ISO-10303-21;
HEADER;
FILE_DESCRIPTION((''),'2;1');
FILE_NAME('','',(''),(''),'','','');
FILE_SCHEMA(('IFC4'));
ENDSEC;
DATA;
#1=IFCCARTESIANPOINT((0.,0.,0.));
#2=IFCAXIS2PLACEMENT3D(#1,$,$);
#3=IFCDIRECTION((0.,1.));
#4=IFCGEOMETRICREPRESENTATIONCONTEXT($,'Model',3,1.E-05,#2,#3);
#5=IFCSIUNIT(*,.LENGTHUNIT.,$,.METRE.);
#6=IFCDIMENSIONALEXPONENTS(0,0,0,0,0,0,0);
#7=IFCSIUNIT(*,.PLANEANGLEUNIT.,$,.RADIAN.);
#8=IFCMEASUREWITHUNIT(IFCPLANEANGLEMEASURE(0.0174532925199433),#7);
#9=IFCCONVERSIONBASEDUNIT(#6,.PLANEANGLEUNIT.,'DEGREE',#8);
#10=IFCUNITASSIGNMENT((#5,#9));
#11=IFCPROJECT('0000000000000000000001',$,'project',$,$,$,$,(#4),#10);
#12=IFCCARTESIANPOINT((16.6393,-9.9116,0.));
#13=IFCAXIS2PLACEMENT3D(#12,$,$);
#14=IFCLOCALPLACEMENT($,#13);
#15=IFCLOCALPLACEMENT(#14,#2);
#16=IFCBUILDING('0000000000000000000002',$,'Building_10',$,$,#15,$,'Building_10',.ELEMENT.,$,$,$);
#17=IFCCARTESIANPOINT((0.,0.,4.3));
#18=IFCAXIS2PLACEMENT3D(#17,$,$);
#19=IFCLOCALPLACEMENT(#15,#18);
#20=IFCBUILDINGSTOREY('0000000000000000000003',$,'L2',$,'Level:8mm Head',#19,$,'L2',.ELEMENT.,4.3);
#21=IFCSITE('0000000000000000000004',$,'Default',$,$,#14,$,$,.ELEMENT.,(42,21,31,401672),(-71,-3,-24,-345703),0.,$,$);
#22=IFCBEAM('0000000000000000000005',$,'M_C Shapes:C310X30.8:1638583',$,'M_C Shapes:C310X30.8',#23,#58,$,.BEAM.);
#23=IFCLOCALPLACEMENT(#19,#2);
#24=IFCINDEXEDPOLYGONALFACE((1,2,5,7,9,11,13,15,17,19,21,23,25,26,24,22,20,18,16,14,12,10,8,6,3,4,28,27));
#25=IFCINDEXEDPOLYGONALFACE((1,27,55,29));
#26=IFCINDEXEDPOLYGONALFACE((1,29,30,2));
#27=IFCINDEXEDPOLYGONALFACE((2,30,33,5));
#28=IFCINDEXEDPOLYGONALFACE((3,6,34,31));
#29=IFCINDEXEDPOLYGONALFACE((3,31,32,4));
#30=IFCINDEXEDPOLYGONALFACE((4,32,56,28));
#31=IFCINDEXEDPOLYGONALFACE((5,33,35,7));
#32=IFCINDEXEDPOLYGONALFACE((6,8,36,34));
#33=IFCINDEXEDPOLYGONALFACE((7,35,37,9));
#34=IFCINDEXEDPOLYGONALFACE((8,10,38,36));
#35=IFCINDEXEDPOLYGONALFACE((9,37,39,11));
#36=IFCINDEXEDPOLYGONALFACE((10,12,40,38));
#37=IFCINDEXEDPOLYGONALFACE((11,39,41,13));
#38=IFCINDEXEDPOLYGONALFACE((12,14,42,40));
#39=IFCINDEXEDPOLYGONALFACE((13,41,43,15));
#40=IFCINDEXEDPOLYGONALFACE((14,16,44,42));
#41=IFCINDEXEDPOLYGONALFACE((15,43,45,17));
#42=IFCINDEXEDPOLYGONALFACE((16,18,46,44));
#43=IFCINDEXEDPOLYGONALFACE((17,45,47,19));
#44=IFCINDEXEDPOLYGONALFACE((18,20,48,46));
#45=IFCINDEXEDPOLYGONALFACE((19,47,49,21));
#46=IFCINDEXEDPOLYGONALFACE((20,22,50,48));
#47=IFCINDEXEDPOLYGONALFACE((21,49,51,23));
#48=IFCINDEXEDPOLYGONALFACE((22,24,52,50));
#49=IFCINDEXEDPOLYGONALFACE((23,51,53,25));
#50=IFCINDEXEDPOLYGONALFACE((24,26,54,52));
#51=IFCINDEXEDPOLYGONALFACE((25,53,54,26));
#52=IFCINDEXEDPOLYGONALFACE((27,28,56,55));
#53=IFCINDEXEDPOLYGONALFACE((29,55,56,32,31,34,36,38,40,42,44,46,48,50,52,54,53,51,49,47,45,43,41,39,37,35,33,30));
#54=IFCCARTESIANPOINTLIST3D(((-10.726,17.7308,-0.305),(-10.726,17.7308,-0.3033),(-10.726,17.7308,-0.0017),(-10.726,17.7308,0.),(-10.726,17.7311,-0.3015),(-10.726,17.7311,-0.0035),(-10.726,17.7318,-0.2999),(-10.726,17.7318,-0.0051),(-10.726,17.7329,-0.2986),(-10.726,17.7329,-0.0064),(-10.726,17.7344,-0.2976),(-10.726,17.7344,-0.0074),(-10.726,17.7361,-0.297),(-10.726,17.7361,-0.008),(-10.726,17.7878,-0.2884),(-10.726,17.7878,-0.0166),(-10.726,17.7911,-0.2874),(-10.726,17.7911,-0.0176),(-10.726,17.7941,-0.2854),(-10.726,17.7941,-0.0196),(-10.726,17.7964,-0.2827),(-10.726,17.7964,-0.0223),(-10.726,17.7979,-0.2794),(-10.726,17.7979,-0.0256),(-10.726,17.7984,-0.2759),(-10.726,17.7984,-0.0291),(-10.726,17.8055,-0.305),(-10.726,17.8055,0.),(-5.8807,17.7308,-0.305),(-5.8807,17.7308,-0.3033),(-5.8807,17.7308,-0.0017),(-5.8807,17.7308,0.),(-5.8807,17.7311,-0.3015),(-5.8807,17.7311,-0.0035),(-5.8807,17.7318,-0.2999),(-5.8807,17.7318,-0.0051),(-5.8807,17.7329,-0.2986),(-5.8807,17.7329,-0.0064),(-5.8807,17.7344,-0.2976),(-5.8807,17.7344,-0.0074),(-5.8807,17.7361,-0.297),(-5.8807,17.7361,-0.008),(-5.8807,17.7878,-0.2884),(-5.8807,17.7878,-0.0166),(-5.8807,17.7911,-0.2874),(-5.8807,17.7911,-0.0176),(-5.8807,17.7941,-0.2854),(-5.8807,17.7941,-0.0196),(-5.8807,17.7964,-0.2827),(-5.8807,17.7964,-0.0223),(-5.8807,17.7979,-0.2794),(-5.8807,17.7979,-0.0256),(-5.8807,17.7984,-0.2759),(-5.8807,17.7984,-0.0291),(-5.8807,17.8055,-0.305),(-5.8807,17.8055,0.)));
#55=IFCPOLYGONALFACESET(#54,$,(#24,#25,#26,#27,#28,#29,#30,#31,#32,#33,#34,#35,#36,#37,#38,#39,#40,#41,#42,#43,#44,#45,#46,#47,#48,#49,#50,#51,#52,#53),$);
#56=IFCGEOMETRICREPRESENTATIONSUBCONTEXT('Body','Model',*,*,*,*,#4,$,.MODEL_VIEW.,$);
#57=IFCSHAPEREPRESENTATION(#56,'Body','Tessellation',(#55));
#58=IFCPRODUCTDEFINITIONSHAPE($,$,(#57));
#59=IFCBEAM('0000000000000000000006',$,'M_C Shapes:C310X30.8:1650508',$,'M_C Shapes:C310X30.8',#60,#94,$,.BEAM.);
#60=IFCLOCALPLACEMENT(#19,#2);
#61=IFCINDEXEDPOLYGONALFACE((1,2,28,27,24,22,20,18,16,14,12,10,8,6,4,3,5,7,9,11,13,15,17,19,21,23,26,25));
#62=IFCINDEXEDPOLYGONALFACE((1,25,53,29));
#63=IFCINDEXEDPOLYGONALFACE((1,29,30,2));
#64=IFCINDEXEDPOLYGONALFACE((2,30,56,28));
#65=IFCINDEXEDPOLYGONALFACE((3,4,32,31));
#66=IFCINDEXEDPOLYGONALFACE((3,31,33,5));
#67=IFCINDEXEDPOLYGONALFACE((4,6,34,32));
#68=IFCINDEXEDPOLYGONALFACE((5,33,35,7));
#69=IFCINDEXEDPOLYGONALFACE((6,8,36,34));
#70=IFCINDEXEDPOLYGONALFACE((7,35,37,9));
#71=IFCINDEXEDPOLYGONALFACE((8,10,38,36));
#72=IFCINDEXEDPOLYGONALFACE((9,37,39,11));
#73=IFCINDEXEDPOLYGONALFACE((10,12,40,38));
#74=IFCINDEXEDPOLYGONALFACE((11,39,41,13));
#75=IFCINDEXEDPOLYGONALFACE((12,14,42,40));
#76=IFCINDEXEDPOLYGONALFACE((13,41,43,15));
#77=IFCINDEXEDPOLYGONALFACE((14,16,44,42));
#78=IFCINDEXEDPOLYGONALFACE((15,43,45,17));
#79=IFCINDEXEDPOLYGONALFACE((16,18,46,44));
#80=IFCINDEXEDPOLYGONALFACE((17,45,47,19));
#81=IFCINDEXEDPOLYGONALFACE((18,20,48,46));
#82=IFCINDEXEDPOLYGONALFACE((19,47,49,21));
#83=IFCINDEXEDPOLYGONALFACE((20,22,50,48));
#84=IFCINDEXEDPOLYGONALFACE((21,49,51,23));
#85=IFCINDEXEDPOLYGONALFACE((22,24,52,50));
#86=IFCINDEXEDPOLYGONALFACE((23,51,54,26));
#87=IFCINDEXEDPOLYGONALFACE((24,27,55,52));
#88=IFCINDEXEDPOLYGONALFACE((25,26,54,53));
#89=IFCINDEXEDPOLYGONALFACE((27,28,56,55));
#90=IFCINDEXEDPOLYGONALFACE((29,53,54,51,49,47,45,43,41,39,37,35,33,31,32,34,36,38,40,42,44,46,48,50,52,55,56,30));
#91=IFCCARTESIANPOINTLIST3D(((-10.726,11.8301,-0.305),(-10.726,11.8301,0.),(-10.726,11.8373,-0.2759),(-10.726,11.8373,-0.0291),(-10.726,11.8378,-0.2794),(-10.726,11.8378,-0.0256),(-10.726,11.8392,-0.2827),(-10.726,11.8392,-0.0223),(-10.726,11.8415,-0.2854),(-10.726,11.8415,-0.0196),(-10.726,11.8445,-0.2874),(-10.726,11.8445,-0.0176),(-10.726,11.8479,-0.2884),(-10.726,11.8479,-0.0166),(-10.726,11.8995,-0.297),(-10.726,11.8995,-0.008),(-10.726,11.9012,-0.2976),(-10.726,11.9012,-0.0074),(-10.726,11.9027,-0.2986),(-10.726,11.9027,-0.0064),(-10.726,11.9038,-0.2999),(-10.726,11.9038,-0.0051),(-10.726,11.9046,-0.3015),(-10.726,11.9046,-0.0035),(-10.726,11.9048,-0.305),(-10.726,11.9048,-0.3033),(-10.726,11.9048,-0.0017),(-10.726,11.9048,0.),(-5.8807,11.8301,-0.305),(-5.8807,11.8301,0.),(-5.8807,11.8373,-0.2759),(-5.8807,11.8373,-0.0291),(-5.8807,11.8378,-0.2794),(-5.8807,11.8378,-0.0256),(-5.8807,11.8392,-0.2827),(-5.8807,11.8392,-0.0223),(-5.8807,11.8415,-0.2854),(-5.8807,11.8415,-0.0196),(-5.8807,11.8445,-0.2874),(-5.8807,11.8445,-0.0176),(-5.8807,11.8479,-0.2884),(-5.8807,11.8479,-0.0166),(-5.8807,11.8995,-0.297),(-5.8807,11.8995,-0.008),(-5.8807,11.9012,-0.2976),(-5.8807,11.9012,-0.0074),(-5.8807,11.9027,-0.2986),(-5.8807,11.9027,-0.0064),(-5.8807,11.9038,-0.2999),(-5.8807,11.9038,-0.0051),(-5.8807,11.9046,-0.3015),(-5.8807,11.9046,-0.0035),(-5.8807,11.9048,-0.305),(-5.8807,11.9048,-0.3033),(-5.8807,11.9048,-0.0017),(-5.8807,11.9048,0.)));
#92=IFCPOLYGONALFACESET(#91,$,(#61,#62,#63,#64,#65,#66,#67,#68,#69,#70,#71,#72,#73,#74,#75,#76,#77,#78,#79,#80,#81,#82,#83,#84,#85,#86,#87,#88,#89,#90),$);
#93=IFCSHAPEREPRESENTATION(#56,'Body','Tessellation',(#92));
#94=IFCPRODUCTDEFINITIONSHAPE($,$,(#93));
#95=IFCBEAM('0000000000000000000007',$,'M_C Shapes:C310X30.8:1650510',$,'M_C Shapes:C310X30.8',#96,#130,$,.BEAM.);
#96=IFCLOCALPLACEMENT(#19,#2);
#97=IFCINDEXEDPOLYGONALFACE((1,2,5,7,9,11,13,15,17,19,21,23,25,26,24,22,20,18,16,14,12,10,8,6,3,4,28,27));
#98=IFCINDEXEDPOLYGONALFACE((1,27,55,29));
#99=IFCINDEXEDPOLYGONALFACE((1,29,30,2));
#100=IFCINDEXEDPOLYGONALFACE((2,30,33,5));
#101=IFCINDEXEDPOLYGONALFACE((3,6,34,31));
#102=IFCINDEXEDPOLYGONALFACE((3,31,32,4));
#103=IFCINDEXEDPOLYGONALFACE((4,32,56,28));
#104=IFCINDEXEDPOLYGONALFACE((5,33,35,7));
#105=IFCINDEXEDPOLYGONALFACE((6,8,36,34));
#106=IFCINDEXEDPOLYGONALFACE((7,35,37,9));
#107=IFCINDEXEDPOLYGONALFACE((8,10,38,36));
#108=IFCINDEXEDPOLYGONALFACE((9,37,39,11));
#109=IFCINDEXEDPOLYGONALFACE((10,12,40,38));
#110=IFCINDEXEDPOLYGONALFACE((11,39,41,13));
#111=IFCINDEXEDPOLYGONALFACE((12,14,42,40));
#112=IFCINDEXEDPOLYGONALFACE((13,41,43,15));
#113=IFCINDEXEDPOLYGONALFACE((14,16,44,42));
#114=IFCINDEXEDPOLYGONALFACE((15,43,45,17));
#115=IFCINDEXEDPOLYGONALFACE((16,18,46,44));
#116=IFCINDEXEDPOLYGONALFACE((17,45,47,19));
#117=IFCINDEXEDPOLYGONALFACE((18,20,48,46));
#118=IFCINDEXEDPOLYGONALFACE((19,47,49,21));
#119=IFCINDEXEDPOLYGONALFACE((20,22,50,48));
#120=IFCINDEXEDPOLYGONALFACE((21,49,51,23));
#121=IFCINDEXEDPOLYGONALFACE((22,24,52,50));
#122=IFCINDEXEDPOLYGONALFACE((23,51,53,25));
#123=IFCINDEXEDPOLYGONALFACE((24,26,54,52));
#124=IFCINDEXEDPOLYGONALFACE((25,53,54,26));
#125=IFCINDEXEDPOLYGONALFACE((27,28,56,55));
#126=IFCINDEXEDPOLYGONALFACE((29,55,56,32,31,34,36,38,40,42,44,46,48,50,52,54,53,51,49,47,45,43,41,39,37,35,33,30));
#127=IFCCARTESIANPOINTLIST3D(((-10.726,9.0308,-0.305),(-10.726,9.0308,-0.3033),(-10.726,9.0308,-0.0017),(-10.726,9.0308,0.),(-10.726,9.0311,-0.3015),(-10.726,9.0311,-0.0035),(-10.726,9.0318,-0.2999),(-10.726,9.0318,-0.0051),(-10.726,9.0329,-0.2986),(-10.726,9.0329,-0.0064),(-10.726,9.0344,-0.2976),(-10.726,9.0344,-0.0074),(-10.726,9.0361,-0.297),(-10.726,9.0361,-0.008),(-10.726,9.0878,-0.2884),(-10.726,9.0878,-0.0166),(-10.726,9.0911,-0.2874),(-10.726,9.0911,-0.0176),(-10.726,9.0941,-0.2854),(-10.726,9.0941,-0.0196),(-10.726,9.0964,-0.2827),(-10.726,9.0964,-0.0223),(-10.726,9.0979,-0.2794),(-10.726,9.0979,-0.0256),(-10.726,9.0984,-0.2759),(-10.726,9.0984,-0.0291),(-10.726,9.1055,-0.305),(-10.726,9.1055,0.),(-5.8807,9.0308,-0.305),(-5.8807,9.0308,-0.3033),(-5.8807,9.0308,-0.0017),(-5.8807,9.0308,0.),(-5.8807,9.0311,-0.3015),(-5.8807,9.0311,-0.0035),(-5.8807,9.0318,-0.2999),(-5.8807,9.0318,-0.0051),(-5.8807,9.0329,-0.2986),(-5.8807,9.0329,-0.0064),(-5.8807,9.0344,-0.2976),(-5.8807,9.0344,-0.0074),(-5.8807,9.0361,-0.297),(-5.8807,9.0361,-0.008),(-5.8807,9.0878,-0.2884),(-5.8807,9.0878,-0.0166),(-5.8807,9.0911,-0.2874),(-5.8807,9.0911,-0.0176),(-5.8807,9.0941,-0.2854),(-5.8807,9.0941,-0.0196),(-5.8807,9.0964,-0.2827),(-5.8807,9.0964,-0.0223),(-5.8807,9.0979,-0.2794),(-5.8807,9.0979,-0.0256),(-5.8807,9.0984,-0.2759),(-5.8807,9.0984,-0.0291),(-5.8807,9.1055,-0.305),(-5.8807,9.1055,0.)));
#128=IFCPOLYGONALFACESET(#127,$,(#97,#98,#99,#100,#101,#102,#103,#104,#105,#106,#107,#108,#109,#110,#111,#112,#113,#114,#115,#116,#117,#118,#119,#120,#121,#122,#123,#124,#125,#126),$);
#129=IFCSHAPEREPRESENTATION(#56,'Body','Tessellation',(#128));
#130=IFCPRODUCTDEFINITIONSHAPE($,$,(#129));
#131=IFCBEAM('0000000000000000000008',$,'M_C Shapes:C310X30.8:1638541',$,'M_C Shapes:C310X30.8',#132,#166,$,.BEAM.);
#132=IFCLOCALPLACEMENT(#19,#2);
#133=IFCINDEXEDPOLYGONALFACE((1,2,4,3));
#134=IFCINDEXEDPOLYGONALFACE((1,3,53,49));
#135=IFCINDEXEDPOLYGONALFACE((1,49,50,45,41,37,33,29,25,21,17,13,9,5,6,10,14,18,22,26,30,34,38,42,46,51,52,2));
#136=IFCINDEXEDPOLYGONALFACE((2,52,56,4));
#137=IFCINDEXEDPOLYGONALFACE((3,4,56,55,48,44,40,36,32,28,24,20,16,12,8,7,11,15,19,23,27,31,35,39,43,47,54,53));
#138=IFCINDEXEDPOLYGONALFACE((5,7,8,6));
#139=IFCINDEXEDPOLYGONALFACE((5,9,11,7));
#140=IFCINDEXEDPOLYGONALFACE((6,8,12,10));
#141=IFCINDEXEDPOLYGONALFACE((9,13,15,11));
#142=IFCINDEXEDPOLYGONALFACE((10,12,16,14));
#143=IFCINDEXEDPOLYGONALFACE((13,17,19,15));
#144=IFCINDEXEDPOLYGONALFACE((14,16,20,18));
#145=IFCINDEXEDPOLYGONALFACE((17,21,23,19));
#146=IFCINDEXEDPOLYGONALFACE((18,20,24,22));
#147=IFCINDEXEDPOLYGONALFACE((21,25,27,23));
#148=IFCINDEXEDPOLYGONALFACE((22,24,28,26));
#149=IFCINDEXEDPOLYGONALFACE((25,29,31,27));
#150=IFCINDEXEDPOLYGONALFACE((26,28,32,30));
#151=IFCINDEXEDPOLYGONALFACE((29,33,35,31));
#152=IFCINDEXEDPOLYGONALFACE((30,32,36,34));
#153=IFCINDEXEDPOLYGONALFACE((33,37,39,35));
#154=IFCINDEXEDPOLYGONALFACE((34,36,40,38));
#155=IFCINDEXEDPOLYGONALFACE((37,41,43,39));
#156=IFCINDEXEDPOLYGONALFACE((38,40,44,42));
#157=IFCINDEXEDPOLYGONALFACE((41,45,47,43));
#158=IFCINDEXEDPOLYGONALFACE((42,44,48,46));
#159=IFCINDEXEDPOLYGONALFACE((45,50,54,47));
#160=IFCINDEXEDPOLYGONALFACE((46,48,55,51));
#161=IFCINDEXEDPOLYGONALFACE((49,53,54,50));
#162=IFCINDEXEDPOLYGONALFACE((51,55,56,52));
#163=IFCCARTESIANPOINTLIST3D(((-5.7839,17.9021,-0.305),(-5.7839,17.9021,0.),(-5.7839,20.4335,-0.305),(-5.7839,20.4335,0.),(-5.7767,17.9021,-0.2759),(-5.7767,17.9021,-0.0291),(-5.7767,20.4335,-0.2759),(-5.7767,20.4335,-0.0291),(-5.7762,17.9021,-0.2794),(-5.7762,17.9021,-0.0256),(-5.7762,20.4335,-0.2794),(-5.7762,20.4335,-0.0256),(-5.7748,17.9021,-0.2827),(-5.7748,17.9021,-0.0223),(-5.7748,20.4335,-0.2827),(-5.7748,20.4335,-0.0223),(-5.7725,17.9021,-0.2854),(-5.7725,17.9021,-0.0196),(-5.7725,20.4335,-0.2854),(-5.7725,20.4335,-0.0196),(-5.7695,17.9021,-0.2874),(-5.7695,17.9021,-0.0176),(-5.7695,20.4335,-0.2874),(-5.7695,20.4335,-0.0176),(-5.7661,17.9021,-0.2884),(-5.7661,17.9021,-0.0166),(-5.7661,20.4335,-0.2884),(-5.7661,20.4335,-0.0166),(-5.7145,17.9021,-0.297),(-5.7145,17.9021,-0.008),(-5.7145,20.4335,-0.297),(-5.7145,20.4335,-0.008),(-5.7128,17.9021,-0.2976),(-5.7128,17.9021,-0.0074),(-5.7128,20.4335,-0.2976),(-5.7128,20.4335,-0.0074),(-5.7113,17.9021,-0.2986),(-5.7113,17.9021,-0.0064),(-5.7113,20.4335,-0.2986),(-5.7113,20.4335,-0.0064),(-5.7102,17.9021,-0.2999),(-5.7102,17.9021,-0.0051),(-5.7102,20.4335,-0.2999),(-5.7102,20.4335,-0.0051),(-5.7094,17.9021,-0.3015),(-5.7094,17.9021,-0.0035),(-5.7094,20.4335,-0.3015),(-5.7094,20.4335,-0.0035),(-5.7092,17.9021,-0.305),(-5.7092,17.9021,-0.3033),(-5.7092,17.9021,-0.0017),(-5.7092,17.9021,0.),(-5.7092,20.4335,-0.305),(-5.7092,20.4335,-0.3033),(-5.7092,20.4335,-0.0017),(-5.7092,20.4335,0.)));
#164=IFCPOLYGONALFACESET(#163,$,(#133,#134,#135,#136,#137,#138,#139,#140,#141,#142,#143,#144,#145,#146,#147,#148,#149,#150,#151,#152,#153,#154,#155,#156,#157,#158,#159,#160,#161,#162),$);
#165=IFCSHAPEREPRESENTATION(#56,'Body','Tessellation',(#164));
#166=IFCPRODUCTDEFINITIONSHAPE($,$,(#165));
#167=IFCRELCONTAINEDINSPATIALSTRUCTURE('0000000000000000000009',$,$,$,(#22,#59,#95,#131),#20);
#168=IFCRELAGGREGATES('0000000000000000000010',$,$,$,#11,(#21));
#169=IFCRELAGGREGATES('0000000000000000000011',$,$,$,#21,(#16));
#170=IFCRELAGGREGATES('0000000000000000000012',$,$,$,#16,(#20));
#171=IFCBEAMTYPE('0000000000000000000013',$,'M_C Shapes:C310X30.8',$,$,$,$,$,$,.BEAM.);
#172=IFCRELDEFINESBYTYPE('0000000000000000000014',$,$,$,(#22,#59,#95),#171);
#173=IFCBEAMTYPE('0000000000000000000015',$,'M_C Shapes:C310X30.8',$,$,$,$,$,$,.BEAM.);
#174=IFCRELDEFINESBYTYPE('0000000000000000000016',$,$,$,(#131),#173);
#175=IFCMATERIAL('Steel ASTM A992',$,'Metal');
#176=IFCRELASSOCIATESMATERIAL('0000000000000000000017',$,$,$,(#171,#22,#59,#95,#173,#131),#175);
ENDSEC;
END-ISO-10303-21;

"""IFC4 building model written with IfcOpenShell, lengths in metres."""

from ifc_helpers import new_model, entity, si_unit, converted_unit, direction, frame, origin, place, context, subcontext, project, spatial, line, arc, indexed_curve, outline, extrude, source, transform, mapped, material, type_object, type_shapes, element, save


model = new_model("IFC4")

# Units and contexts
model_context = context("Model", 3, precision=1e-05, world=origin(), true_north=direction((0.0, 1.0)))
body_context = subcontext(model_context, "Body", "Model", "MODEL_VIEW")
ifc_project = project(units=[si_unit("LENGTHUNIT", "METRE"), converted_unit("PLANEANGLEUNIT", "DEGREE", entity("IfcPlaneAngleMeasure", 0.0174532925199433), si_unit("PLANEANGLEUNIT", "RADIAN"), dimensions=[0, 0, 0, 0, 0, 0, 0])], contexts=[model_context])

# Site, building, storey
site_placement = place(None, frame((16.6393, -9.9116, 0.0)))
site = spatial("IfcSite", under=ifc_project, at=site_placement, Name="Default", CompositionType="ELEMENT", RefLatitude=(42, 21, 31, 401672), RefLongitude=(-71, -3, -24, -345703), RefElevation=0.0)
building_placement = place(site_placement, origin())
building = spatial("IfcBuilding", under=site, at=building_placement, Name="Building_10", LongName="Building_10", CompositionType="ELEMENT")
storey_placement = place(building_placement, frame((0.0, 0.0, 4.3)))
storey = spatial("IfcBuildingStorey", under=building, at=storey_placement, Name="L2", ObjectType="Level:8mm Head", LongName="L2", CompositionType="ELEMENT", Elevation=4.3)

# Shared definitions
ifc_material_1 = material(Name="Steel ASTM A992", Category="Metal")

# Beams
beam_type_1 = type_object("IfcBeamType", Name="M_C Shapes:C310X30.8", PredefinedType="BEAM", material=ifc_material_1)
shared_shape_1 = source(origin(), body_context, "Body", "SweptSolid", [
    extrude(outline(indexed_curve([(-0.0406, -0.1525), (0.0341, -0.1525), (0.0341, -0.1508), (0.0326, -0.1467), (0.0288, -0.1445), (-0.0228, -0.1359), (-0.0305, -0.1316), (-0.0335, -0.1234), (-0.0335, 0.1234), (-0.0305, 0.1316), (-0.0228, 0.1359), (0.0288, 0.1445), (0.0326, 0.1467), (0.0341, 0.1508), (0.0341, 0.1525), (-0.0406, 0.1525)], segments=[line(1, 2, 3), arc(3, 4, 5), line(5, 6), arc(6, 7, 8), line(8, 9), arc(9, 10, 11), line(11, 12), arc(12, 13, 14), line(14, 15, 16, 1)], self_intersect=False)), frame((-2.4226, -0.0229, 0.0), z_axis=(1.0, 0.0, 0.0), x_axis=(0.0, -1.0, 0.0)), (0.0, 0.0, 1.0), 4.8453),
])
type_shapes(beam_type_1, [shared_shape_1])
beam_1_placement = place(storey_placement, frame((-8.3033, 17.7878, -0.1525)))
element("IfcBeam", 1, at=beam_1_placement, inside=storey, type_object=beam_type_1, material=ifc_material_1, Name="M_C Shapes:C310X30.8:1638583", ObjectType="M_C Shapes:C310X30.8", PredefinedType="BEAM", context=body_context, shape_type="MappedRepresentation", body=[
    mapped(shared_shape_1, transform((0.0, 0.0, 0.0), scale=1.0)),
])
beam_2_placement = place(storey_placement, frame((-8.3033, 11.8478, -0.1525), z_axis=(0.0, 0.0, 1.0), x_axis=(-1.0, 0.0, 0.0)))
element("IfcBeam", 2, at=beam_2_placement, inside=storey, type_object=beam_type_1, material=ifc_material_1, Name="M_C Shapes:C310X30.8:1650508", ObjectType="M_C Shapes:C310X30.8", PredefinedType="BEAM", context=body_context, shape_type="MappedRepresentation", body=[
    mapped(shared_shape_1, transform((0.0, 0.0, 0.0), scale=1.0)),
])
beam_3_placement = place(storey_placement, frame((-8.3033, 9.0878, -0.1525)))
element("IfcBeam", 3, at=beam_3_placement, inside=storey, type_object=beam_type_1, material=ifc_material_1, Name="M_C Shapes:C310X30.8:1650510", ObjectType="M_C Shapes:C310X30.8", PredefinedType="BEAM", context=body_context, shape_type="MappedRepresentation", body=[
    mapped(shared_shape_1, transform((0.0, 0.0, 0.0), scale=1.0)),
])
beam_type_2 = type_object("IfcBeamType", Name="M_C Shapes:C310X30.8", PredefinedType="BEAM", material=ifc_material_1)
shared_shape_2 = source(origin(), body_context, "Body", "SweptSolid", [
    extrude(outline(indexed_curve([(-0.0406, -0.1525), (0.0341, -0.1525), (0.0341, -0.1508), (0.0326, -0.1467), (0.0288, -0.1445), (-0.0228, -0.1359), (-0.0305, -0.1316), (-0.0335, -0.1234), (-0.0335, 0.1234), (-0.0305, 0.1316), (-0.0228, 0.1359), (0.0288, 0.1445), (0.0326, 0.1467), (0.0341, 0.1508), (0.0341, 0.1525), (-0.0406, 0.1525)], segments=[line(1, 2, 3), arc(3, 4, 5), line(5, 6), arc(6, 7, 8), line(8, 9), arc(9, 10, 11), line(11, 12), arc(12, 13, 14), line(14, 15, 16, 1)], self_intersect=False)), frame((-1.2657, -0.0229, 0.0), z_axis=(1.0, 0.0, 0.0), x_axis=(0.0, -1.0, 0.0)), (0.0, 0.0, 1.0), 2.5314),
])
type_shapes(beam_type_2, [shared_shape_2])
for number, where, z_axis, x_axis, name in (
    (4, (-5.7662, 19.1678, -0.1525), (0.0, 0.0, 1.0), (0.0, 1.0, 0.0), "M_C Shapes:C310X30.8:1638541"),
):
    element("IfcBeam", number, at=place(storey_placement, frame(where, z_axis=z_axis, x_axis=x_axis)), inside=storey, type_object=beam_type_2, material=ifc_material_1, Name=name, ObjectType="M_C Shapes:C310X30.8", PredefinedType="BEAM", context=body_context, shape_type="MappedRepresentation", body=[
        mapped(shared_shape_2, transform((0.0, 0.0, 0.0), scale=1.0)),
    ])

save(model, "model.ifc")
